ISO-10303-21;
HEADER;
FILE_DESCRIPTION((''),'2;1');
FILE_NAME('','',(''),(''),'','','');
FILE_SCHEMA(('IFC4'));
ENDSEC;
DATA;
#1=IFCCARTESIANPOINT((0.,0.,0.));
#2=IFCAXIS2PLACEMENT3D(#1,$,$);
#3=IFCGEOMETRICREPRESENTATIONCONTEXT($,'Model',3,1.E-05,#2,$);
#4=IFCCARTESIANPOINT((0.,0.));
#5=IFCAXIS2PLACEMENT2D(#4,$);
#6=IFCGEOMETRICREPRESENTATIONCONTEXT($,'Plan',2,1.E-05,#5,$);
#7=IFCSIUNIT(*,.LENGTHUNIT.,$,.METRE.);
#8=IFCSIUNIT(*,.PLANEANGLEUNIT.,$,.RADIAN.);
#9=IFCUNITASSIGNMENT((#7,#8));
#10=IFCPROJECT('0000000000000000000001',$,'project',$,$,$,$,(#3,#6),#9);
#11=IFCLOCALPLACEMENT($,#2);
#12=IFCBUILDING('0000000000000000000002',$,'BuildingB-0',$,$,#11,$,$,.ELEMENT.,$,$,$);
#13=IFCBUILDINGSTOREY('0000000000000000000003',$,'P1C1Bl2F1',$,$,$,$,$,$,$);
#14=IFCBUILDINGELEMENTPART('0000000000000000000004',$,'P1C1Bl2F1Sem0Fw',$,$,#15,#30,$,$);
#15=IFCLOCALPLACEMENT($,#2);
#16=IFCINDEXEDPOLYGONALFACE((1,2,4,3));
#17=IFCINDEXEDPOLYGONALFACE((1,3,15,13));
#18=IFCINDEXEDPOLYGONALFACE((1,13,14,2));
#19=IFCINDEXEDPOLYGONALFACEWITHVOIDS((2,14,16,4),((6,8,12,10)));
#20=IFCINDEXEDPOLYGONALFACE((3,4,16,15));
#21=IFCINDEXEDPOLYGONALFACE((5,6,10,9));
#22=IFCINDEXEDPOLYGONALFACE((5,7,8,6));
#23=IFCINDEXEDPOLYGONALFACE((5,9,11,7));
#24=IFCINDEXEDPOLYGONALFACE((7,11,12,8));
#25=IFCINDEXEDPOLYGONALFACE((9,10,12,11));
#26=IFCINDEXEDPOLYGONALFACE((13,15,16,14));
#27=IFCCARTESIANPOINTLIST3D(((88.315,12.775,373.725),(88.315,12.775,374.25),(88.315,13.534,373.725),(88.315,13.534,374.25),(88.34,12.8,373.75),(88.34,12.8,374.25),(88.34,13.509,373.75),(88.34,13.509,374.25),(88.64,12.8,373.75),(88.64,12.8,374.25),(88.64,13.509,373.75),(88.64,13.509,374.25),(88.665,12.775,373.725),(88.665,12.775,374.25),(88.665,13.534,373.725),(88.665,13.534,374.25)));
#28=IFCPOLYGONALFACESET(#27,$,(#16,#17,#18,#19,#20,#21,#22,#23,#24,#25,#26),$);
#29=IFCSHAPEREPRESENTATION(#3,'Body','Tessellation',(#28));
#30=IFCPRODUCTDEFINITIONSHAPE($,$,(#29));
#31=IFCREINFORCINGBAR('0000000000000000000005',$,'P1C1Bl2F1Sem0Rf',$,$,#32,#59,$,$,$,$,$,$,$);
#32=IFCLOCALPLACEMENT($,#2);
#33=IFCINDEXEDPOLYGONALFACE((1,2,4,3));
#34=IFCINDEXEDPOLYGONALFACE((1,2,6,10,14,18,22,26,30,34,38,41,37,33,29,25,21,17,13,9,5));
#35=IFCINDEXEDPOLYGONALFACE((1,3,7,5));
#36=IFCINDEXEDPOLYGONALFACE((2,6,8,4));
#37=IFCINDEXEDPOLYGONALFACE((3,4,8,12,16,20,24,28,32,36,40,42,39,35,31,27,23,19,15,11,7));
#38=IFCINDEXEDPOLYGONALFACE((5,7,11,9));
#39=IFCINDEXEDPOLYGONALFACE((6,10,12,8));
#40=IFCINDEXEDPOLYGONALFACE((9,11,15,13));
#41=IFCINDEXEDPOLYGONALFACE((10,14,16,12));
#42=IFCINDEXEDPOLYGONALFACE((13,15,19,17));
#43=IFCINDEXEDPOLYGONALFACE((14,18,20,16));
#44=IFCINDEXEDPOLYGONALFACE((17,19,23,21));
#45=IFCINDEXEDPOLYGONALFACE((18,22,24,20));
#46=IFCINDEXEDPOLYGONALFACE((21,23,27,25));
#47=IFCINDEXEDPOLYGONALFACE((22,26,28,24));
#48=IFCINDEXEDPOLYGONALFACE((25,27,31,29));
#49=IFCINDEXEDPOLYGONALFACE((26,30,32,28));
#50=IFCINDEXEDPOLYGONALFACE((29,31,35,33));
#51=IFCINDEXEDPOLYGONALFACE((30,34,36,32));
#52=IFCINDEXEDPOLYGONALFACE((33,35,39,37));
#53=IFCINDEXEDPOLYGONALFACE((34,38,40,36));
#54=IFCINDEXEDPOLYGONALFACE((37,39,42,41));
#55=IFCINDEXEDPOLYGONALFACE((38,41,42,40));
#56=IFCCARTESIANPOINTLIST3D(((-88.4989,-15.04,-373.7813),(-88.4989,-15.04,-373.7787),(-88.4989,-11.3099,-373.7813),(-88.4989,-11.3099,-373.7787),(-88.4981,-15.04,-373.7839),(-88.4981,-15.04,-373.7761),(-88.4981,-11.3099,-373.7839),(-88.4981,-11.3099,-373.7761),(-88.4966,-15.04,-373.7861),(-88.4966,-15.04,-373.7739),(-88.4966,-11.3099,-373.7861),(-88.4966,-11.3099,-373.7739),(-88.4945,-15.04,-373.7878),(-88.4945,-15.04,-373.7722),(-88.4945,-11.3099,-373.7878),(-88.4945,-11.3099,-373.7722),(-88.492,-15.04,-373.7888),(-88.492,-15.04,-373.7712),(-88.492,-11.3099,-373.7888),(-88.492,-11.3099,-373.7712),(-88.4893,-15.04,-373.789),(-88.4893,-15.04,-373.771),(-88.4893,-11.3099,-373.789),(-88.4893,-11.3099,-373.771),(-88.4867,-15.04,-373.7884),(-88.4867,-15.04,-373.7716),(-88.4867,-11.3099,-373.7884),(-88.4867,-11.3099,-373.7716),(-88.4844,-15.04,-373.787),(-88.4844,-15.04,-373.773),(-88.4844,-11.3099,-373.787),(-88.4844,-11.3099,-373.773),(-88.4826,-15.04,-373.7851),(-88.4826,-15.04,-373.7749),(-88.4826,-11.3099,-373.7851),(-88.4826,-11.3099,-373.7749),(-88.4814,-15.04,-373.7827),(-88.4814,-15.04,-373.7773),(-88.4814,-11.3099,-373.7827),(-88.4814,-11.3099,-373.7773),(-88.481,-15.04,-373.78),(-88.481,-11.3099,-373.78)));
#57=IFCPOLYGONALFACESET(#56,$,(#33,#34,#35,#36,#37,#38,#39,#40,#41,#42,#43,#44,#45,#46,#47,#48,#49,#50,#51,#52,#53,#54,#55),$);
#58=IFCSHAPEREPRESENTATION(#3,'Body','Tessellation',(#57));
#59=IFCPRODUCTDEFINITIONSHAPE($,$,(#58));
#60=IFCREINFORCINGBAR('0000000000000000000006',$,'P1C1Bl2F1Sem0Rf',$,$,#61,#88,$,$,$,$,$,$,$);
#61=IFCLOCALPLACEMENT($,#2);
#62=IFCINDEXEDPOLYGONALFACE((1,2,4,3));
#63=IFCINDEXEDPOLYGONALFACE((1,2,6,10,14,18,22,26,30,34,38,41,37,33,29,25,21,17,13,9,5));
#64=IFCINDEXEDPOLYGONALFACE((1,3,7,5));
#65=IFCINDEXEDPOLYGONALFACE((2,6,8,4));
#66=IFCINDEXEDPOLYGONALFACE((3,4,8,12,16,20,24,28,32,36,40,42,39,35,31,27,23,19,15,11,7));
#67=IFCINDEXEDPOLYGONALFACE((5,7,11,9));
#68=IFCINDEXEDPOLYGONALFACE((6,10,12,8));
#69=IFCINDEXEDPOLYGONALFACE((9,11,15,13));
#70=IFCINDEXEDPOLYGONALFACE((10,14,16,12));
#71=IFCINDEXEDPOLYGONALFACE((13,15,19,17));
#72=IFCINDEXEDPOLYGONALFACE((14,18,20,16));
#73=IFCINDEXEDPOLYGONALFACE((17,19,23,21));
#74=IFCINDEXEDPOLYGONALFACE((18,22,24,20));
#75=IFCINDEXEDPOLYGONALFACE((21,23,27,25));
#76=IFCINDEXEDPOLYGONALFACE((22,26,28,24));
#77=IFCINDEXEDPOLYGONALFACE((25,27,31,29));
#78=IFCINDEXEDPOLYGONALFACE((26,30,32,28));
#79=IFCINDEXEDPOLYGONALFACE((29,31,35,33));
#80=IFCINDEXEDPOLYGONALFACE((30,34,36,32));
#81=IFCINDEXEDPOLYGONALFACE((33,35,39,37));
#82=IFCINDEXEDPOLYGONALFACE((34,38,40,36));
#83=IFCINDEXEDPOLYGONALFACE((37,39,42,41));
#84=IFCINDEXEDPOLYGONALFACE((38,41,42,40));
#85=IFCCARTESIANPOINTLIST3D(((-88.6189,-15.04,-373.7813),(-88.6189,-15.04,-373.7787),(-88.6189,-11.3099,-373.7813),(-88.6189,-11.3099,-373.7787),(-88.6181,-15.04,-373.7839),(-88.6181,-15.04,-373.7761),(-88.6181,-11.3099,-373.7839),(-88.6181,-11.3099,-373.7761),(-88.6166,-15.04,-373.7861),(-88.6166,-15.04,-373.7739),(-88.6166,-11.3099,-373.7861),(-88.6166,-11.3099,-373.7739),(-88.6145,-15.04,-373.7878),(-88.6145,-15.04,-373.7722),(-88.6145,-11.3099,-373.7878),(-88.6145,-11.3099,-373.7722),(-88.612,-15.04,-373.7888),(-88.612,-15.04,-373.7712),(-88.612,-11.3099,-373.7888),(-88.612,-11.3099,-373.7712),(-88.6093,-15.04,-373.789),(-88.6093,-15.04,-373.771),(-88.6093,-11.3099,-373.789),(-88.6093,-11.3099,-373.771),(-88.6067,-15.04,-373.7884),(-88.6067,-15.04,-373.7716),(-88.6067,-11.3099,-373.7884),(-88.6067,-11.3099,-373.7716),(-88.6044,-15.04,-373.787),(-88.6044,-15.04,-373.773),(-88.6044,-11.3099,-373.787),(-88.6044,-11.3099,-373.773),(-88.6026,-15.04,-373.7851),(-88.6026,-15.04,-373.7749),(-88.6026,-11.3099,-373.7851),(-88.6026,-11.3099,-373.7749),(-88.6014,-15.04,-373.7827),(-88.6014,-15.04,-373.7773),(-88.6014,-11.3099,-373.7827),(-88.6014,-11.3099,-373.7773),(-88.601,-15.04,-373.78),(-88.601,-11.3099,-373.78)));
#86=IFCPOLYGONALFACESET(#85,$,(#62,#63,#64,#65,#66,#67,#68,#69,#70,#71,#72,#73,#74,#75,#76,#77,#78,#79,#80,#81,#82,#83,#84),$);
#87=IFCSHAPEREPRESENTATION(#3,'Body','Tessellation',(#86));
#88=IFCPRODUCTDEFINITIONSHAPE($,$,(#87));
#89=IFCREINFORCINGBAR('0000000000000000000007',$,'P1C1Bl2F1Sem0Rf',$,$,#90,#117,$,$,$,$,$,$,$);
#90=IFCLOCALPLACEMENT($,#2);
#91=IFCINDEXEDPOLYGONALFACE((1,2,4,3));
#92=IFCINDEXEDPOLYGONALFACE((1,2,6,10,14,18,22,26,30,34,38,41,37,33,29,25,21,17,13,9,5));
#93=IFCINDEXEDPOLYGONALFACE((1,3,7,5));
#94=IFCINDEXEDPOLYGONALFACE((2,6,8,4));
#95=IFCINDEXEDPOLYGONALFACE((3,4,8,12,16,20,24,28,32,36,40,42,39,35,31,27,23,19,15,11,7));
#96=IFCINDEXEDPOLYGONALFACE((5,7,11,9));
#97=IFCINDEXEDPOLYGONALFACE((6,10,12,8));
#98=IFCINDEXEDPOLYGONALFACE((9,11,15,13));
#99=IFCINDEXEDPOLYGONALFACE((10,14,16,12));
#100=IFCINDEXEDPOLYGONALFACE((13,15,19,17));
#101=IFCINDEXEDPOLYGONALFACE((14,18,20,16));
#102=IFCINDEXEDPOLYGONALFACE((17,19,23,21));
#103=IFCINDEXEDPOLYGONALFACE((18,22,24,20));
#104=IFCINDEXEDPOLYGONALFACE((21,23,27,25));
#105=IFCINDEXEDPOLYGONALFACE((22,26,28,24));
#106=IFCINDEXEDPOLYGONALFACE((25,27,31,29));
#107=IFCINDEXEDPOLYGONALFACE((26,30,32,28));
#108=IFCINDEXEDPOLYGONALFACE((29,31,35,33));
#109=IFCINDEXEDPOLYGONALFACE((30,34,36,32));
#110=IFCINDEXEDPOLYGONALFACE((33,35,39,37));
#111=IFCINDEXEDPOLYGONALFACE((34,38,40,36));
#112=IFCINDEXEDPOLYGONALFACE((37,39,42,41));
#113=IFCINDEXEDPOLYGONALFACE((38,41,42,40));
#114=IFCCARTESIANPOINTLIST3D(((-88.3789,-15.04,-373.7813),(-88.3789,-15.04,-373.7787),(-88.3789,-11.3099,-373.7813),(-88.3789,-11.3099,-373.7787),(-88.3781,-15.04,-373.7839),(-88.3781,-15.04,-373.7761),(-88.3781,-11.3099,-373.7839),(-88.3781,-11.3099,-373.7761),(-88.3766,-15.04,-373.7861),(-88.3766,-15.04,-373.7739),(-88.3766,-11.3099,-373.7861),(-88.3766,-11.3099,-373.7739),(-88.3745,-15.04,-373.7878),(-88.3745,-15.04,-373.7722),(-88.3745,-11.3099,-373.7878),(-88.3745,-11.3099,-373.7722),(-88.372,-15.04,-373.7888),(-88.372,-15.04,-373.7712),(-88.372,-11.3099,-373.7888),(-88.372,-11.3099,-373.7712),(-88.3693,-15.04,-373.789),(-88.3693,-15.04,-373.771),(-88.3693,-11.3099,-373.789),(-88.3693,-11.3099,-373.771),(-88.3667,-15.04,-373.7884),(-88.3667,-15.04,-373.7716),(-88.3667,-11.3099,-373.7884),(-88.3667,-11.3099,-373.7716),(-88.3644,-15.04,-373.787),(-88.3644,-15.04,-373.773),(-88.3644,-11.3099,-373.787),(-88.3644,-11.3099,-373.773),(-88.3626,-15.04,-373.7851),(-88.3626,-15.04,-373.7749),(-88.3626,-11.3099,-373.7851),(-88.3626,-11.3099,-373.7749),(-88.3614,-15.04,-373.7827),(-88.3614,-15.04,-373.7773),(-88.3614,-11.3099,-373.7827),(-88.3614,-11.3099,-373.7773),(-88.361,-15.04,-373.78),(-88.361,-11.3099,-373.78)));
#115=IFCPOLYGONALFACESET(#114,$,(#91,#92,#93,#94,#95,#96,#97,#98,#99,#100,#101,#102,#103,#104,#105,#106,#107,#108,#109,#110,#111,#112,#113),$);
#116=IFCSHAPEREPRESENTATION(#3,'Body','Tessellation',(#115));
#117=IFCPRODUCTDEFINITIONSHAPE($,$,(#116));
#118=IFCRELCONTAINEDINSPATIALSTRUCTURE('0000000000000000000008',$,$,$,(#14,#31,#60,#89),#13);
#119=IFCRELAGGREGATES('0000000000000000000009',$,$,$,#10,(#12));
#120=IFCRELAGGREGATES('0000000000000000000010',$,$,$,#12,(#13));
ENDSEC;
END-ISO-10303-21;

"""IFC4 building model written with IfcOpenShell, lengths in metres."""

from ifc_helpers import new_model, entity, si_unit, origin, origin_2d, place, context, project, spatial, polyline, outline, extrude, element, save


model = new_model("IFC4")

# Units and contexts
model_context = context("Model", 3, precision=1e-05, world=origin())
plan_context = context("Plan", 2, precision=1e-05, world=origin_2d())
ifc_project = project(units=[si_unit("LENGTHUNIT", "METRE"), si_unit("PLANEANGLEUNIT", "RADIAN")], contexts=[model_context, plan_context])

# Building, storey
building_placement = place(None, origin())
building = spatial("IfcBuilding", under=ifc_project, at=building_placement, Name="BuildingB-0", CompositionType="ELEMENT")
storey = spatial("IfcBuildingStorey", under=building, Name="P1C1Bl2F1")

# Building element part, opening
building_element_part_1 = element("IfcBuildingElementPart", 1, inside=storey, Name="P1C1Bl2F1Sem0Fw", context=model_context, shape_type="SweptSolid", body=[
    extrude(outline(polyline([(88.665, 12.775, 373.725), (88.315, 12.775, 373.725), (88.315, 13.534, 373.725), (88.665, 13.534, 373.725), (88.665, 12.775, 373.725)])), None, (0.0, 0.0, 1.0), 0.525),
])
element("IfcOpeningElement", 2, inside=storey, cuts=building_element_part_1, context=model_context, shape_type="SweptSolid", body=[
    extrude(outline(polyline([(88.64, 12.8, 373.75), (88.34, 12.8, 373.75), (88.34, 13.509, 373.75), (88.64, 13.509, 373.75), (88.64, 12.8, 373.75)])), None, (0.0, 0.0, 1.0), 0.5),
])

# Reinforcing bars
element("IfcReinforcingBar", 3, inside=storey, Name="P1C1Bl2F1Sem0Rf", context=model_context, shape_type="SweptSolid", body=[
    entity("IfcSurfaceCurveSweptAreaSolid", entity("IfcCircleProfileDef", "AREA", None, None, 0.009), None, entity("IfcPolyline", [entity("IfcCartesianPoint", [88.49, 11.3099, 373.78]), entity("IfcCartesianPoint", [88.49, 15.04, 373.78])]), None, None, entity("IfcPlane", entity("IfcAxis2Placement3D", entity("IfcCartesianPoint", [88.49, 11.3099, 373.78]), entity("IfcDirection", [0.0, 0.0, 1.0]), entity("IfcDirection", [1.0, 0.0, 0.0])))),
])
element("IfcReinforcingBar", 4, inside=storey, Name="P1C1Bl2F1Sem0Rf", context=model_context, shape_type="SweptSolid", body=[
    entity("IfcSurfaceCurveSweptAreaSolid", entity("IfcCircleProfileDef", "AREA", None, None, 0.009), None, entity("IfcPolyline", [entity("IfcCartesianPoint", [88.61, 11.3099, 373.78]), entity("IfcCartesianPoint", [88.61, 15.04, 373.78])]), None, None, entity("IfcPlane", entity("IfcAxis2Placement3D", entity("IfcCartesianPoint", [88.61, 11.3099, 373.78]), entity("IfcDirection", [0.0, 0.0, 1.0]), entity("IfcDirection", [1.0, 0.0, 0.0])))),
])
element("IfcReinforcingBar", 5, inside=storey, Name="P1C1Bl2F1Sem0Rf", context=model_context, shape_type="SweptSolid", body=[
    entity("IfcSurfaceCurveSweptAreaSolid", entity("IfcCircleProfileDef", "AREA", None, None, 0.009), None, entity("IfcPolyline", [entity("IfcCartesianPoint", [88.37, 11.3099, 373.78]), entity("IfcCartesianPoint", [88.37, 15.04, 373.78])]), None, None, entity("IfcPlane", entity("IfcAxis2Placement3D", entity("IfcCartesianPoint", [88.37, 11.3099, 373.78]), entity("IfcDirection", [0.0, 0.0, 1.0]), entity("IfcDirection", [1.0, 0.0, 0.0])))),
])

save(model, "model.ifc")
